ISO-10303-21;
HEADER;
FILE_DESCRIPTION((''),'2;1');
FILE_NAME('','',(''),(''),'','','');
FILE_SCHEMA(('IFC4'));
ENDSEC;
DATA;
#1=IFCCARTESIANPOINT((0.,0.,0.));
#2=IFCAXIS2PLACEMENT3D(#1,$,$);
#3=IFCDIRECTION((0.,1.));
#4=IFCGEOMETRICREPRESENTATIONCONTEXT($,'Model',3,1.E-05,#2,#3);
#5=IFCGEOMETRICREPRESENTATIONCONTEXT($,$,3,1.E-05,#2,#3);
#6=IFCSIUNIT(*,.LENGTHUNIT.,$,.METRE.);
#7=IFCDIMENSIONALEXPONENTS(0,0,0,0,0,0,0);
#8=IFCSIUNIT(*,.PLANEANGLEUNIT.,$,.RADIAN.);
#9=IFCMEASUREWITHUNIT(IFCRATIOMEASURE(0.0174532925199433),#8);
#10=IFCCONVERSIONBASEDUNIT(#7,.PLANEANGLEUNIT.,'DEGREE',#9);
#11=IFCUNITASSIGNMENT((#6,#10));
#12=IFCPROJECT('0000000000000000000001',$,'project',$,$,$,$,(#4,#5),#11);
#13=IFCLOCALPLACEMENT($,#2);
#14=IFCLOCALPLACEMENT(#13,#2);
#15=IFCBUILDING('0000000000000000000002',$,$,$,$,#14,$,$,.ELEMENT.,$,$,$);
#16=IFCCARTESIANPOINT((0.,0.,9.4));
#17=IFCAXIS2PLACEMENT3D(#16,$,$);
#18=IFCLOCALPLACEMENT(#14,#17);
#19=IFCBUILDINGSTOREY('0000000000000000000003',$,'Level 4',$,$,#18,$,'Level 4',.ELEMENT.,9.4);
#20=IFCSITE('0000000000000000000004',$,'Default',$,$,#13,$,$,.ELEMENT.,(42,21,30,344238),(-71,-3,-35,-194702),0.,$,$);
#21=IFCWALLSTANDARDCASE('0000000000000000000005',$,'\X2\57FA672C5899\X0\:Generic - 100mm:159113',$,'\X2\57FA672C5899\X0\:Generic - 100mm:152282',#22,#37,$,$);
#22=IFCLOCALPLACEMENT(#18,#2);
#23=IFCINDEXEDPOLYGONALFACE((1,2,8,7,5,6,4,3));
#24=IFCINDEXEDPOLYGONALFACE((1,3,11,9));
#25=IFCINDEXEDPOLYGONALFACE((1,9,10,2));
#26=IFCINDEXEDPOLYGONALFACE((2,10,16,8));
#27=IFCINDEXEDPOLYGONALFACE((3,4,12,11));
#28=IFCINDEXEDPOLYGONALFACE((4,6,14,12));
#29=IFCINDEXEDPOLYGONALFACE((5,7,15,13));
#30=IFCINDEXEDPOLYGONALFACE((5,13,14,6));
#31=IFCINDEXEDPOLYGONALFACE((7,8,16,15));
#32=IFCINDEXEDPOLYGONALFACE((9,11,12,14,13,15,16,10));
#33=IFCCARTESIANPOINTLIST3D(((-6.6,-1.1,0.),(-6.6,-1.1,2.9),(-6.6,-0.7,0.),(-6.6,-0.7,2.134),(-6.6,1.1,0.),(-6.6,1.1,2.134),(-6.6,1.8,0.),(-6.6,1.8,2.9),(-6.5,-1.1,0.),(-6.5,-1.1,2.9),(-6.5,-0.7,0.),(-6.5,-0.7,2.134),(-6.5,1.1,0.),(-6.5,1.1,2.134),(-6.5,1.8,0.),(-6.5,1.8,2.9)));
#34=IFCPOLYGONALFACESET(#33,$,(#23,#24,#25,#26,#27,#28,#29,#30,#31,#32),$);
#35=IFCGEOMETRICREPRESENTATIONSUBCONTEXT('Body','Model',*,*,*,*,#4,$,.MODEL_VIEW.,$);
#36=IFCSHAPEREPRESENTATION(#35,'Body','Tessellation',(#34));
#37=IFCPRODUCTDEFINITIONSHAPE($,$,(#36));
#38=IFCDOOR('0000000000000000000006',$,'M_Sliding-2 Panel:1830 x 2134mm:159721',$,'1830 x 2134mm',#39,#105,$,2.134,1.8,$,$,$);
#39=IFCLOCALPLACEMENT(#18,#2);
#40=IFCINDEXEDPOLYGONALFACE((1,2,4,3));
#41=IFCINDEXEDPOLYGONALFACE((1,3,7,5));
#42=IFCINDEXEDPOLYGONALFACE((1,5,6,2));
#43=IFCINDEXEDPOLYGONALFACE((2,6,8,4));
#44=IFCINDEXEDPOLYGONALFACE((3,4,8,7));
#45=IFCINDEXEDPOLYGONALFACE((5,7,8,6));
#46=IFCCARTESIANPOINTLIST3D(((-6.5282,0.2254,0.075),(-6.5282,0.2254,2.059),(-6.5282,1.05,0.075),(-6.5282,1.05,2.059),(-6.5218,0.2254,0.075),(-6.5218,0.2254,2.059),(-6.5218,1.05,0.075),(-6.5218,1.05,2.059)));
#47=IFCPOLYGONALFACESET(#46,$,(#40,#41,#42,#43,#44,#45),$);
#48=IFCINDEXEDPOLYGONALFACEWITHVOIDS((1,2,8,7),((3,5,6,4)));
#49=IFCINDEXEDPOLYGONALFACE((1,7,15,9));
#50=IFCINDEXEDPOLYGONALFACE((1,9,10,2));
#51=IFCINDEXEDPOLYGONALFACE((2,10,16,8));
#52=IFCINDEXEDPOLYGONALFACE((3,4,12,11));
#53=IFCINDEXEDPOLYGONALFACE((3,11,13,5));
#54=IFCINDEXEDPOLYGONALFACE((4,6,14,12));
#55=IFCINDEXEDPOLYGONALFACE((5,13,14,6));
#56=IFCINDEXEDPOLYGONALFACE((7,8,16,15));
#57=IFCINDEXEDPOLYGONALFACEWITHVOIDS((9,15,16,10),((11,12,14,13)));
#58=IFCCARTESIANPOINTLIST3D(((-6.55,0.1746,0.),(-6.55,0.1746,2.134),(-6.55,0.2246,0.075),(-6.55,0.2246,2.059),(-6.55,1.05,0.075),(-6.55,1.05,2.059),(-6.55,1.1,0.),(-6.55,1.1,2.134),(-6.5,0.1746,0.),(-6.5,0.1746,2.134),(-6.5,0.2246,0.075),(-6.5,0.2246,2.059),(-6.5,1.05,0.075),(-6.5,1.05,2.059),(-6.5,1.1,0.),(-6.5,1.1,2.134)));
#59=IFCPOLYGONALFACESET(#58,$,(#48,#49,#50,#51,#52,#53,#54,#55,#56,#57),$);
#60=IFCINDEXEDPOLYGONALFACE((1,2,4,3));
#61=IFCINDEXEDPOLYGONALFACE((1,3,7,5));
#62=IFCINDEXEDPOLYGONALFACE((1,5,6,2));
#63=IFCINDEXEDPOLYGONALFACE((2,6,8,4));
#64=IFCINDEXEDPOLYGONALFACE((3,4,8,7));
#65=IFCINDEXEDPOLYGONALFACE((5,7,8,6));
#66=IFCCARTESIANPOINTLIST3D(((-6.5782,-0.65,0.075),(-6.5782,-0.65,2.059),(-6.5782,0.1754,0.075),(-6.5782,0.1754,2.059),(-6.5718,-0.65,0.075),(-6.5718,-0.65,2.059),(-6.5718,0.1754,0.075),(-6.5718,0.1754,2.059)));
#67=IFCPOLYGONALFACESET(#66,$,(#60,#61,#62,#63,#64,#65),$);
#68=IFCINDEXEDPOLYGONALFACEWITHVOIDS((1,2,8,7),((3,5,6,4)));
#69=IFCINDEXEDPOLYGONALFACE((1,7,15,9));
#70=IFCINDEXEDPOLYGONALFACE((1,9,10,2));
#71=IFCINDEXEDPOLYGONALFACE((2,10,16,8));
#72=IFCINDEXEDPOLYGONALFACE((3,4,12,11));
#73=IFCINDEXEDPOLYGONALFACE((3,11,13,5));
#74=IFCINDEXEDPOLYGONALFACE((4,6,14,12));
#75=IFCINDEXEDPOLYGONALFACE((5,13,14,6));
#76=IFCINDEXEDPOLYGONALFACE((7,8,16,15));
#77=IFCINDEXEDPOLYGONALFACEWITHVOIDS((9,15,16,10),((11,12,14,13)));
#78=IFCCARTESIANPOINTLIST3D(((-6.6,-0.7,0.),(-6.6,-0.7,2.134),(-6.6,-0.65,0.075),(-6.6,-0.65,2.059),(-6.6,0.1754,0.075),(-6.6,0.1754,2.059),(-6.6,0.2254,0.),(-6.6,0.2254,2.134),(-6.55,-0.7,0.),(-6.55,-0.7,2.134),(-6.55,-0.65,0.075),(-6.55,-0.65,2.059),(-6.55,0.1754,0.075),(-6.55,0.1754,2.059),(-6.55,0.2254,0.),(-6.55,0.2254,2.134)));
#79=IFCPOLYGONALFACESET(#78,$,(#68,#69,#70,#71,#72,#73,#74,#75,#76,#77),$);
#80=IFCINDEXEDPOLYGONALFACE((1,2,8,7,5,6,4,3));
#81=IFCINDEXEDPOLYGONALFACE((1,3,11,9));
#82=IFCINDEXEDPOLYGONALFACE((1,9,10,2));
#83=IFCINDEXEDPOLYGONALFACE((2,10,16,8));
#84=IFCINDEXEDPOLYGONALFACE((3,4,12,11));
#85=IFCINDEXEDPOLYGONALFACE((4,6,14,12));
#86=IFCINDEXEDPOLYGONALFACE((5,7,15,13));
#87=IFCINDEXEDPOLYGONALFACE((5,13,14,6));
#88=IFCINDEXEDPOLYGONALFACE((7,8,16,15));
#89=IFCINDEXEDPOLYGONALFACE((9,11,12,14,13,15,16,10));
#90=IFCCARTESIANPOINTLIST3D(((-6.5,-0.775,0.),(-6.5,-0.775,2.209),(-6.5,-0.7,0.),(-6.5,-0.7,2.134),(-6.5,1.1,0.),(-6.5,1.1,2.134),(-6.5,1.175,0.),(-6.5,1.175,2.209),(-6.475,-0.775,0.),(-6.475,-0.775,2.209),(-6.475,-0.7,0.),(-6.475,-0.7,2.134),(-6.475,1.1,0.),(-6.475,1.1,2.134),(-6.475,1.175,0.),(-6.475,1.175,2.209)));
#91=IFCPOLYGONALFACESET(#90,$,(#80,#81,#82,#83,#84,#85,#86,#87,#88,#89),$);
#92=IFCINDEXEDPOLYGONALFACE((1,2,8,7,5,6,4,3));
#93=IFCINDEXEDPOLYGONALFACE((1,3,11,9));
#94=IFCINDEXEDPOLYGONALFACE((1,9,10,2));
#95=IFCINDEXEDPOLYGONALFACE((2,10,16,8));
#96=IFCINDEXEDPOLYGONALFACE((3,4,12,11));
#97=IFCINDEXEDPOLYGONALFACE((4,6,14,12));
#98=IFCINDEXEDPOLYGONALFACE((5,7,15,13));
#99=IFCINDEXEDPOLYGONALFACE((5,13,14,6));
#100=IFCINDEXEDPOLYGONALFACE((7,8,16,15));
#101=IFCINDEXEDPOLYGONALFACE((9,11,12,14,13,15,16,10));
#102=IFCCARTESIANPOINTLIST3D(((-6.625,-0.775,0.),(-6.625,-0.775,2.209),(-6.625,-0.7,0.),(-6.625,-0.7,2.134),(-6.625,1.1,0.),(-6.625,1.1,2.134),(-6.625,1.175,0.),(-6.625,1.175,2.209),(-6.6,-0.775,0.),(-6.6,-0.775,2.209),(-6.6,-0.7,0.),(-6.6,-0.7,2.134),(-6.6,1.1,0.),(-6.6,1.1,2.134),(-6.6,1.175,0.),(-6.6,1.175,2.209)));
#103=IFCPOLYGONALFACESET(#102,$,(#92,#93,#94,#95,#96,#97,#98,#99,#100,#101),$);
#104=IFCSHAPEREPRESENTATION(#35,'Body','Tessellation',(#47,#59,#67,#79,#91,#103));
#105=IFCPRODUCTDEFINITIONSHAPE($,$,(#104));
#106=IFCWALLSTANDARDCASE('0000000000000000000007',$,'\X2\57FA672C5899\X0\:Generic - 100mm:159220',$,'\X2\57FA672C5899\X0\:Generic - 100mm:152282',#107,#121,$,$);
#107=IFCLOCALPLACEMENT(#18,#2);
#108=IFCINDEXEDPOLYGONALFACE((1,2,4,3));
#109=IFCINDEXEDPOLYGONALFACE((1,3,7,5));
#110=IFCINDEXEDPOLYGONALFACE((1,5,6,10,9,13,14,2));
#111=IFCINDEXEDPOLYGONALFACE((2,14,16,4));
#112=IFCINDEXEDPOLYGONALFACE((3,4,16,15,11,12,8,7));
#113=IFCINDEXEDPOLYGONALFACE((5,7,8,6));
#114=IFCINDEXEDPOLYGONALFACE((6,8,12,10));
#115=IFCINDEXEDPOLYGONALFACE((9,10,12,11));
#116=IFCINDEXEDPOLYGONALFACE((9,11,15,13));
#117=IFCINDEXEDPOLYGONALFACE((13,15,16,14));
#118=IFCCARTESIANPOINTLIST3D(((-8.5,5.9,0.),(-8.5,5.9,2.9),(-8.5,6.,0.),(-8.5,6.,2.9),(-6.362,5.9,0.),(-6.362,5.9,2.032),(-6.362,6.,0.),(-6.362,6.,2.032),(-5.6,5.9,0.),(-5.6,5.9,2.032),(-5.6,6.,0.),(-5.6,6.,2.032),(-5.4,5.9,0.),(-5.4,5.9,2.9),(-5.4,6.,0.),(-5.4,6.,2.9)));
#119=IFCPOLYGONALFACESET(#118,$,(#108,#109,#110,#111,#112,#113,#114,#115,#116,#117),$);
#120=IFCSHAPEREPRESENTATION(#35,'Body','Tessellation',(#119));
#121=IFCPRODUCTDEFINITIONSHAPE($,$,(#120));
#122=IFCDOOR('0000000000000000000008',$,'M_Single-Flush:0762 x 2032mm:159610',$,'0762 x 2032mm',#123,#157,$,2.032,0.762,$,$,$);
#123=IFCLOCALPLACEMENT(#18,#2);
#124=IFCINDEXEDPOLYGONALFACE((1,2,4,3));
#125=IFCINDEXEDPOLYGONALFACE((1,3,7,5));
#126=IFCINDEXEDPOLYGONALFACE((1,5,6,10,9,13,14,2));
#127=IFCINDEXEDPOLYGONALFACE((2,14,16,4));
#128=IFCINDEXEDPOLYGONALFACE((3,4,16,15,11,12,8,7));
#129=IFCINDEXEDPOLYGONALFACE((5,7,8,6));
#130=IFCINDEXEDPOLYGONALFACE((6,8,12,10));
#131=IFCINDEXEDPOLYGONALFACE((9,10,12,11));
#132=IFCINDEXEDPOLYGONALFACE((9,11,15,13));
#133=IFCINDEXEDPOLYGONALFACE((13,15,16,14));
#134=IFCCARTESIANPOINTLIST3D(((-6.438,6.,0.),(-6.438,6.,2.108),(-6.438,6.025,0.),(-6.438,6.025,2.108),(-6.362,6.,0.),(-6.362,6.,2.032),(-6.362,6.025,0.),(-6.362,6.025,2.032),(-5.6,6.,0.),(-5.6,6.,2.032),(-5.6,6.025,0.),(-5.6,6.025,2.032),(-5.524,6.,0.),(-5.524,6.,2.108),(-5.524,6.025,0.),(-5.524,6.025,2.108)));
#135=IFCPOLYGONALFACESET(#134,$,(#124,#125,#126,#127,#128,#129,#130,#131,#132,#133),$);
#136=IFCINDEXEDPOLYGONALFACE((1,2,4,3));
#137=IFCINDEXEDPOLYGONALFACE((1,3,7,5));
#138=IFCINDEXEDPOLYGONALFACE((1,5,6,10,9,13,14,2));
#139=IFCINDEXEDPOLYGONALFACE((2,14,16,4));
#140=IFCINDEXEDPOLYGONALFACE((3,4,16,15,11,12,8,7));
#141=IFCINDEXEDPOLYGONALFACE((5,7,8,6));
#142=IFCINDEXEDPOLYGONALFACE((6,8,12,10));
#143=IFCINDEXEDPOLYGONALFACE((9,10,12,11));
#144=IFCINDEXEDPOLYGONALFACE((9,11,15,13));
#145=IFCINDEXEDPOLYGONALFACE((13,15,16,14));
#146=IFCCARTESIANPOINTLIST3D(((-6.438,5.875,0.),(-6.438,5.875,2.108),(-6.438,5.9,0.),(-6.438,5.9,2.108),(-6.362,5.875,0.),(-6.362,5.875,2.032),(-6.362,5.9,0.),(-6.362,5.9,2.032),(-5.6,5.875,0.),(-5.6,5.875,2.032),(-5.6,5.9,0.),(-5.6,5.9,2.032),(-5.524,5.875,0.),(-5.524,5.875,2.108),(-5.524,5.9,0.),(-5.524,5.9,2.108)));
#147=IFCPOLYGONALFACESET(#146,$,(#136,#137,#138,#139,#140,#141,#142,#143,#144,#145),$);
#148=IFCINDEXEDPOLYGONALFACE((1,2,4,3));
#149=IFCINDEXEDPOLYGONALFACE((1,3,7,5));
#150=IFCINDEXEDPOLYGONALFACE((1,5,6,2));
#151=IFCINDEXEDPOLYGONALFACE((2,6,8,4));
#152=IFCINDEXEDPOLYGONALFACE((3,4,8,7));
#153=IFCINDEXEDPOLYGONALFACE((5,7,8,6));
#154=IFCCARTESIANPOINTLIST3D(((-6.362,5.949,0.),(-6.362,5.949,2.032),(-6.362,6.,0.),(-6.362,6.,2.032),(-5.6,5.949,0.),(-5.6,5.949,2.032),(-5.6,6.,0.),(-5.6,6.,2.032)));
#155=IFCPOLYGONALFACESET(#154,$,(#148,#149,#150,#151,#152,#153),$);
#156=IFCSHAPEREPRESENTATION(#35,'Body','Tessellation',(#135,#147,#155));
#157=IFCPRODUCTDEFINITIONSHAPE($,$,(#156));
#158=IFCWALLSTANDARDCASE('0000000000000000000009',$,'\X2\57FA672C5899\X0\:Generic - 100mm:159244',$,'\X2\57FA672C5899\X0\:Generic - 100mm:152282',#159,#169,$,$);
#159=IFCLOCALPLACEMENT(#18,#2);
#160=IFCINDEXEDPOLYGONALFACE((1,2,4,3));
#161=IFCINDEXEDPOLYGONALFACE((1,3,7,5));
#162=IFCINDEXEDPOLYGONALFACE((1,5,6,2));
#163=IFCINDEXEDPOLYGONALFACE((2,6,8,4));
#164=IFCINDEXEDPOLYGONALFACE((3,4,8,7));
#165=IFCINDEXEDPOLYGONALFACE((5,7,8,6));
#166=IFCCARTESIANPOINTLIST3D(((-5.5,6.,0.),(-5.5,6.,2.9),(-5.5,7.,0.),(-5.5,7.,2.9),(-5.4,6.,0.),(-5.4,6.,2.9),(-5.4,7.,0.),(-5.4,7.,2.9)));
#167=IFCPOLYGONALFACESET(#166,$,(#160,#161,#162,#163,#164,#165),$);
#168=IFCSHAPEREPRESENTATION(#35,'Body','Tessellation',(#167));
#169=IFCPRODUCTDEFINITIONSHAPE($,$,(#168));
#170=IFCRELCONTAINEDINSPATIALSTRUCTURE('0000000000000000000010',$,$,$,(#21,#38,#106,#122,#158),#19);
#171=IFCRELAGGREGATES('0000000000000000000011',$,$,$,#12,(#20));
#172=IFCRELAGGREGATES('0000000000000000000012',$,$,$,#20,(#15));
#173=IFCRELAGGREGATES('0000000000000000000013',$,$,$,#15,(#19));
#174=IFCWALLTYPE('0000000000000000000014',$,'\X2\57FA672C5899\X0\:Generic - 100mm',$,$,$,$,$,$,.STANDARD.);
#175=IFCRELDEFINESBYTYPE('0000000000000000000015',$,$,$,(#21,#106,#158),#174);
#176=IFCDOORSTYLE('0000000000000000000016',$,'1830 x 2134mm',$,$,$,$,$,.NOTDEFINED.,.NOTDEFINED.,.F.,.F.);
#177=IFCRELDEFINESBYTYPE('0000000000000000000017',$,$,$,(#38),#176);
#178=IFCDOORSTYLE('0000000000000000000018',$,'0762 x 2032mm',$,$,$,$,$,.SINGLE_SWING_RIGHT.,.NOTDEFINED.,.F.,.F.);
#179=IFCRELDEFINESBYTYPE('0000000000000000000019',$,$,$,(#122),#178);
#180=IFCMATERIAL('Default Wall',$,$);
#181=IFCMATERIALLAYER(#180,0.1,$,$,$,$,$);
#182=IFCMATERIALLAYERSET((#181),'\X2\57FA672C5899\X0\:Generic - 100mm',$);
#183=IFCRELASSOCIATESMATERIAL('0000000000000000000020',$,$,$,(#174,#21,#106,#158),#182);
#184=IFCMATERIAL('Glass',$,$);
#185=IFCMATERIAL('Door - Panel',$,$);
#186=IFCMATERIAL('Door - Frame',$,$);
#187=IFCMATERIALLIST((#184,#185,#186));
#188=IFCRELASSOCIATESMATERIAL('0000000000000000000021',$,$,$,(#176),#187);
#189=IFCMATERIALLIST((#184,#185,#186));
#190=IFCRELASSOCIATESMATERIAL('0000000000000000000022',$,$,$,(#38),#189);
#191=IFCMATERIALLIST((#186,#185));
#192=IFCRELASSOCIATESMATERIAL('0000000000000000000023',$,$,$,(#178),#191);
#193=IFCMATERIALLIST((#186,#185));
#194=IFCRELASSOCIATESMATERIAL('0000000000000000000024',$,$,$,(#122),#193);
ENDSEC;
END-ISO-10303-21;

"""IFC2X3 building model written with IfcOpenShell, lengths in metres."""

from ifc_helpers import new_model, entity, si_unit, converted_unit, direction, frame, frame_2d, origin, origin_2d_with_axis, place, context, subcontext, project, spatial, polyline, rectangle, outline, extrude, clip, bounded_halfspace, source, transform, mapped, material, material_list, layer, layer_set, layer_usage, type_object, type_shapes, element, fill, save


model = new_model("IFC2X3")

# Units and contexts
model_context = context("Model", 3, precision=1e-05, world=origin(), true_north=direction((0.0, 1.0)))
context_of_model = context(None, 3, precision=1e-05, world=origin(), true_north=direction((0.0, 1.0)))
body_context = subcontext(model_context, "Body", "Model", "MODEL_VIEW")
ifc_project = project(units=[si_unit("LENGTHUNIT", "METRE"), converted_unit("PLANEANGLEUNIT", "DEGREE", entity("IfcRatioMeasure", 0.0174532925199433), si_unit("PLANEANGLEUNIT", "RADIAN"), dimensions=[0, 0, 0, 0, 0, 0, 0])], contexts=[model_context, context_of_model])

# Site, building, storey
site_placement = place(None, origin())
site = spatial("IfcSite", under=ifc_project, at=site_placement, Name="Default", CompositionType="ELEMENT", RefLatitude=(42, 21, 30, 344238), RefLongitude=(-71, -3, -35, -194702), RefElevation=0.0)
building_placement = place(site_placement, origin())
building = spatial("IfcBuilding", under=site, at=building_placement, CompositionType="ELEMENT")
storey_placement = place(building_placement, frame((0.0, 0.0, 9.4)))
storey = spatial("IfcBuildingStorey", under=building, at=storey_placement, Name="Level 4", LongName="Level 4", CompositionType="ELEMENT", Elevation=9.4)

# Shared definitions
ifc_material_1 = material(Name="Default Wall")

# Shared definitions
ifc_material_2 = material(Name="Glass")

# Walls, openings, doors
ifc_layer_1 = layer(ifc_material_1, 0.1)
ifc_layer_set_1 = layer_set([ifc_layer_1], Name="基本墙:Generic - 100mm")
ifc_layer_usage_1 = layer_usage(ifc_layer_set_1, "AXIS2", "NEGATIVE", 0.05)
wall_type_1 = type_object("IfcWallType", Name="基本墙:Generic - 100mm", PredefinedType="STANDARD", material=ifc_layer_set_1)
wall_1_placement = place(storey_placement, frame((-6.55, -1.1, 0.0), z_axis=(0.0, 0.0, 1.0), x_axis=(0.0, 1.0, 0.0)))
wall_1 = element("IfcWallStandardCase", 1, at=wall_1_placement, inside=storey, type_object=wall_type_1, material=ifc_layer_usage_1, Name="基本墙:Generic - 100mm:159113", ObjectType="基本墙:Generic - 100mm:152282", context=body_context, shape_type="Clipping", body=[
    clip(extrude(rectangle(XDim=2.9, YDim=0.1, at=frame_2d((1.45, 0.0), x_axis=(-1.0, 0.0))), origin(), (0.0, 0.0, 1.0), 3.2), bounded_halfspace(frame((0.0, -0.05, 2.9), z_axis=(0.0, 0.0, -1.0), x_axis=(-1.0, 0.0, 0.0)), True, frame((0.0, -0.05, 2.9), z_axis=(0.0, 0.0, -1.0), x_axis=(-1.0, 0.0, 0.0)), polyline([(0.0, 0.0), (0.0, 0.1), (-2.9, 0.1), (-2.9, 0.0), (0.0, 0.0)]))),
])
opening_1_placement = place(wall_1_placement, frame((0.4, -0.05, 0.0)))
opening_1 = element("IfcOpeningElement", 2, at=opening_1_placement, cuts=wall_1, ObjectType="Opening", context=body_context, shape_type="SweptSolid", body=[
    extrude(rectangle(XDim=2.134, YDim=1.8, at=frame_2d((1.067, 0.9), x_axis=(-1.0, 0.0))), frame((0.0, 0.0, 0.0), z_axis=(0.0, 1.0, 0.0), x_axis=(0.0, 0.0, 1.0)), (0.0, 0.0, 1.0), 0.1),
])
ifc_material_3 = material(Name="Door - Panel")
ifc_material_4 = material(Name="Door - Frame")
ifc_material_list_1 = material_list([ifc_material_2, ifc_material_3, ifc_material_4])
ifc_material_list_2 = material_list([ifc_material_2, ifc_material_3, ifc_material_4])
door_style_1 = type_object("IfcDoorStyle", Name="1830 x 2134mm", ConstructionType="NOTDEFINED", OperationType="NOTDEFINED", ParameterTakesPrecedence=False, Sizeable=False, material=ifc_material_list_2)
shared_shape_1 = source(origin(), body_context, "Body", "SweptSolid", [
    extrude(rectangle(XDim=0.0063, YDim=0.8246, at=origin_2d_with_axis()), frame((1.3377, 0.025, 0.075), z_axis=(0.0, 0.0, 1.0), x_axis=(0.0, -1.0, 0.0)), (0.0, 0.0, 1.0), 1.984),
    extrude(outline(polyline([(-0.4627, -1.067), (0.4627, -1.067), (0.4627, 1.067), (-0.4627, 1.067), (-0.4627, -1.067)]), holes=[polyline([(-0.4127, -0.992), (-0.4127, 0.992), (0.4127, 0.992), (0.4127, -0.992), (-0.4127, -0.992)])]), frame((1.3373, 0.0, 1.067), z_axis=(0.0, 1.0, 0.0), x_axis=(1.0, 0.0, 0.0)), (0.0, 0.0, 1.0), 0.05),
    extrude(rectangle(XDim=0.0063, YDim=0.8254, at=frame_2d((0.0, 0.0), x_axis=(1.0, 0.0))), frame((0.4627, 0.075, 0.075), z_axis=(0.0, 0.0, 1.0), x_axis=(0.0, -1.0, 0.0)), (0.0, 0.0, 1.0), 1.984),
    extrude(outline(polyline([(-1.067, -0.4627), (1.067, -0.4627), (1.067, 0.4627), (-1.067, 0.4627), (-1.067, -0.4627)]), holes=[polyline([(-0.992, -0.4127), (-0.992, 0.4127), (0.992, 0.4127), (0.992, -0.4127), (-0.992, -0.4127)])]), frame((0.4627, 0.05, 1.067), z_axis=(0.0, 1.0, 0.0), x_axis=(0.0, 0.0, -1.0)), (0.0, 0.0, 1.0), 0.05),
    extrude(outline(polyline([(-1.0857, -0.975), (1.1233, -0.975), (1.1233, 0.975), (-1.0857, 0.975), (-1.0857, 0.9), (1.0482, 0.9), (1.0482, -0.9), (-1.0857, -0.9), (-1.0857, -0.975)])), frame((0.9, -0.025, 1.0857), z_axis=(0.0, 1.0, 0.0), x_axis=(0.0, 0.0, 1.0)), (0.0, 0.0, 1.0), 0.025),
    extrude(outline(polyline([(-0.975, -1.0857), (-0.9, -1.0857), (-0.9, 1.0482), (0.9, 1.0482), (0.9, -1.0857), (0.975, -1.0857), (0.975, 1.1233), (-0.975, 1.1233), (-0.975, -1.0857)])), frame((0.9, 0.1, 1.0857), z_axis=(0.0, 1.0, 0.0), x_axis=(-1.0, 0.0, 0.0)), (0.0, 0.0, 1.0), 0.025),
])
type_shapes(door_style_1, [shared_shape_1])
door_1_placement = place(opening_1_placement, origin())
door_1 = element("IfcDoor", 3, at=door_1_placement, inside=storey, type_object=door_style_1, material=ifc_material_list_1, Name="M_Sliding-2 Panel:1830 x 2134mm:159721", ObjectType="1830 x 2134mm", OverallHeight=2.134, OverallWidth=1.8, context=body_context, shape_type="MappedRepresentation", body=[
    mapped(shared_shape_1, transform((0.0, 0.0, 0.0), scale=1.0)),
])
fill(opening_1, door_1)
ifc_layer_usage_2 = layer_usage(ifc_layer_set_1, "AXIS2", "NEGATIVE", 0.05)
wall_2_placement = place(storey_placement, frame((-8.5, 5.95, 0.0)))
wall_2 = element("IfcWallStandardCase", 4, at=wall_2_placement, inside=storey, type_object=wall_type_1, material=ifc_layer_usage_2, Name="基本墙:Generic - 100mm:159220", ObjectType="基本墙:Generic - 100mm:152282", context=body_context, shape_type="Clipping", body=[
    clip(extrude(rectangle(XDim=3.1, YDim=0.1, at=frame_2d((1.55, 0.0), x_axis=(-1.0, 0.0))), origin(), (0.0, 0.0, 1.0), 3.2), bounded_halfspace(frame((0.0, -0.05, 2.9), z_axis=(0.0, 0.0, -1.0), x_axis=(0.0, -1.0, 0.0)), True, frame((0.0, -0.05, 2.9), z_axis=(0.0, 0.0, -1.0), x_axis=(0.0, -1.0, 0.0)), polyline([(0.0, 0.0), (-0.1, 0.0), (-0.1, -3.1), (0.0, -3.1), (0.0, 0.0)]))),
])
opening_2_placement = place(wall_2_placement, frame((2.138, -0.05, 0.0)))
opening_2 = element("IfcOpeningElement", 5, at=opening_2_placement, cuts=wall_2, ObjectType="Opening", context=body_context, shape_type="SweptSolid", body=[
    extrude(rectangle(XDim=0.762, YDim=2.032, at=frame_2d((1.016, 0.381), x_axis=(0.0, 1.0))), frame((0.0, 0.0, 0.0), z_axis=(0.0, 1.0, 0.0), x_axis=(0.0, 0.0, 1.0)), (0.0, 0.0, 1.0), 0.1),
])
ifc_material_list_3 = material_list([ifc_material_4, ifc_material_3])
ifc_material_list_4 = material_list([ifc_material_4, ifc_material_3])
door_style_2 = type_object("IfcDoorStyle", Name="0762 x 2032mm", ConstructionType="NOTDEFINED", OperationType="SINGLE_SWING_RIGHT", ParameterTakesPrecedence=False, Sizeable=False, material=ifc_material_list_4)
shared_shape_2 = source(origin(), body_context, "Body", "SweptSolid", [
    extrude(outline(polyline([(-0.457, -1.073), (0.457, -1.073), (0.457, 1.035), (0.381, 1.035), (0.381, -0.997), (-0.381, -0.997), (-0.381, 1.035), (-0.457, 1.035), (-0.457, -1.073)])), frame((0.381, 0.1, 1.035), z_axis=(0.0, 1.0, 0.0), x_axis=(1.0, 0.0, 0.0)), (0.0, 0.0, 1.0), 0.025),
    extrude(outline(polyline([(-1.073, -0.457), (1.035, -0.457), (1.035, -0.381), (-0.997, -0.381), (-0.997, 0.381), (1.035, 0.381), (1.035, 0.457), (-1.073, 0.457), (-1.073, -0.457)])), frame((0.381, -0.025, 1.035), z_axis=(0.0, 1.0, 0.0), x_axis=(0.0, 0.0, -1.0)), (0.0, 0.0, 1.0), 0.025),
    extrude(rectangle(XDim=0.051, YDim=0.762, at=origin_2d_with_axis()), frame((0.381, 0.0745, 0.0), z_axis=(0.0, 0.0, 1.0), x_axis=(0.0, 1.0, 0.0)), (0.0, 0.0, 1.0), 2.032),
])
type_shapes(door_style_2, [shared_shape_2])
door_2_placement = place(opening_2_placement, origin())
door_2 = element("IfcDoor", 6, at=door_2_placement, inside=storey, type_object=door_style_2, material=ifc_material_list_3, Name="M_Single-Flush:0762 x 2032mm:159610", ObjectType="0762 x 2032mm", OverallHeight=2.032, OverallWidth=0.762, context=body_context, shape_type="MappedRepresentation", body=[
    mapped(shared_shape_2, transform((0.0, 0.0, 0.0), scale=1.0)),
])
fill(opening_2, door_2)

# Wall
ifc_layer_usage_3 = layer_usage(ifc_layer_set_1, "AXIS2", "NEGATIVE", 0.05)
wall_3_placement = place(storey_placement, frame((-5.45, 6.0, 0.0), z_axis=(0.0, 0.0, 1.0), x_axis=(0.0, 1.0, 0.0)))
element("IfcWallStandardCase", 7, at=wall_3_placement, inside=storey, type_object=wall_type_1, material=ifc_layer_usage_3, Name="基本墙:Generic - 100mm:159244", ObjectType="基本墙:Generic - 100mm:152282", context=body_context, shape_type="Clipping", body=[
    clip(extrude(rectangle(XDim=1.0, YDim=0.1, at=frame_2d((0.5, 0.0), x_axis=(-1.0, 0.0))), origin(), (0.0, 0.0, 1.0), 3.2), bounded_halfspace(frame((0.0, -0.05, 2.9), z_axis=(0.0, 0.0, -1.0), x_axis=(-1.0, 0.0, 0.0)), True, frame((0.0, -0.05, 2.9), z_axis=(0.0, 0.0, -1.0), x_axis=(-1.0, 0.0, 0.0)), polyline([(0.0, 0.0), (0.0, 0.1), (-1.0, 0.1), (-1.0, 0.0), (-0.9, 0.0), (0.0, 0.0)]))),
])

save(model, "model.ifc")
